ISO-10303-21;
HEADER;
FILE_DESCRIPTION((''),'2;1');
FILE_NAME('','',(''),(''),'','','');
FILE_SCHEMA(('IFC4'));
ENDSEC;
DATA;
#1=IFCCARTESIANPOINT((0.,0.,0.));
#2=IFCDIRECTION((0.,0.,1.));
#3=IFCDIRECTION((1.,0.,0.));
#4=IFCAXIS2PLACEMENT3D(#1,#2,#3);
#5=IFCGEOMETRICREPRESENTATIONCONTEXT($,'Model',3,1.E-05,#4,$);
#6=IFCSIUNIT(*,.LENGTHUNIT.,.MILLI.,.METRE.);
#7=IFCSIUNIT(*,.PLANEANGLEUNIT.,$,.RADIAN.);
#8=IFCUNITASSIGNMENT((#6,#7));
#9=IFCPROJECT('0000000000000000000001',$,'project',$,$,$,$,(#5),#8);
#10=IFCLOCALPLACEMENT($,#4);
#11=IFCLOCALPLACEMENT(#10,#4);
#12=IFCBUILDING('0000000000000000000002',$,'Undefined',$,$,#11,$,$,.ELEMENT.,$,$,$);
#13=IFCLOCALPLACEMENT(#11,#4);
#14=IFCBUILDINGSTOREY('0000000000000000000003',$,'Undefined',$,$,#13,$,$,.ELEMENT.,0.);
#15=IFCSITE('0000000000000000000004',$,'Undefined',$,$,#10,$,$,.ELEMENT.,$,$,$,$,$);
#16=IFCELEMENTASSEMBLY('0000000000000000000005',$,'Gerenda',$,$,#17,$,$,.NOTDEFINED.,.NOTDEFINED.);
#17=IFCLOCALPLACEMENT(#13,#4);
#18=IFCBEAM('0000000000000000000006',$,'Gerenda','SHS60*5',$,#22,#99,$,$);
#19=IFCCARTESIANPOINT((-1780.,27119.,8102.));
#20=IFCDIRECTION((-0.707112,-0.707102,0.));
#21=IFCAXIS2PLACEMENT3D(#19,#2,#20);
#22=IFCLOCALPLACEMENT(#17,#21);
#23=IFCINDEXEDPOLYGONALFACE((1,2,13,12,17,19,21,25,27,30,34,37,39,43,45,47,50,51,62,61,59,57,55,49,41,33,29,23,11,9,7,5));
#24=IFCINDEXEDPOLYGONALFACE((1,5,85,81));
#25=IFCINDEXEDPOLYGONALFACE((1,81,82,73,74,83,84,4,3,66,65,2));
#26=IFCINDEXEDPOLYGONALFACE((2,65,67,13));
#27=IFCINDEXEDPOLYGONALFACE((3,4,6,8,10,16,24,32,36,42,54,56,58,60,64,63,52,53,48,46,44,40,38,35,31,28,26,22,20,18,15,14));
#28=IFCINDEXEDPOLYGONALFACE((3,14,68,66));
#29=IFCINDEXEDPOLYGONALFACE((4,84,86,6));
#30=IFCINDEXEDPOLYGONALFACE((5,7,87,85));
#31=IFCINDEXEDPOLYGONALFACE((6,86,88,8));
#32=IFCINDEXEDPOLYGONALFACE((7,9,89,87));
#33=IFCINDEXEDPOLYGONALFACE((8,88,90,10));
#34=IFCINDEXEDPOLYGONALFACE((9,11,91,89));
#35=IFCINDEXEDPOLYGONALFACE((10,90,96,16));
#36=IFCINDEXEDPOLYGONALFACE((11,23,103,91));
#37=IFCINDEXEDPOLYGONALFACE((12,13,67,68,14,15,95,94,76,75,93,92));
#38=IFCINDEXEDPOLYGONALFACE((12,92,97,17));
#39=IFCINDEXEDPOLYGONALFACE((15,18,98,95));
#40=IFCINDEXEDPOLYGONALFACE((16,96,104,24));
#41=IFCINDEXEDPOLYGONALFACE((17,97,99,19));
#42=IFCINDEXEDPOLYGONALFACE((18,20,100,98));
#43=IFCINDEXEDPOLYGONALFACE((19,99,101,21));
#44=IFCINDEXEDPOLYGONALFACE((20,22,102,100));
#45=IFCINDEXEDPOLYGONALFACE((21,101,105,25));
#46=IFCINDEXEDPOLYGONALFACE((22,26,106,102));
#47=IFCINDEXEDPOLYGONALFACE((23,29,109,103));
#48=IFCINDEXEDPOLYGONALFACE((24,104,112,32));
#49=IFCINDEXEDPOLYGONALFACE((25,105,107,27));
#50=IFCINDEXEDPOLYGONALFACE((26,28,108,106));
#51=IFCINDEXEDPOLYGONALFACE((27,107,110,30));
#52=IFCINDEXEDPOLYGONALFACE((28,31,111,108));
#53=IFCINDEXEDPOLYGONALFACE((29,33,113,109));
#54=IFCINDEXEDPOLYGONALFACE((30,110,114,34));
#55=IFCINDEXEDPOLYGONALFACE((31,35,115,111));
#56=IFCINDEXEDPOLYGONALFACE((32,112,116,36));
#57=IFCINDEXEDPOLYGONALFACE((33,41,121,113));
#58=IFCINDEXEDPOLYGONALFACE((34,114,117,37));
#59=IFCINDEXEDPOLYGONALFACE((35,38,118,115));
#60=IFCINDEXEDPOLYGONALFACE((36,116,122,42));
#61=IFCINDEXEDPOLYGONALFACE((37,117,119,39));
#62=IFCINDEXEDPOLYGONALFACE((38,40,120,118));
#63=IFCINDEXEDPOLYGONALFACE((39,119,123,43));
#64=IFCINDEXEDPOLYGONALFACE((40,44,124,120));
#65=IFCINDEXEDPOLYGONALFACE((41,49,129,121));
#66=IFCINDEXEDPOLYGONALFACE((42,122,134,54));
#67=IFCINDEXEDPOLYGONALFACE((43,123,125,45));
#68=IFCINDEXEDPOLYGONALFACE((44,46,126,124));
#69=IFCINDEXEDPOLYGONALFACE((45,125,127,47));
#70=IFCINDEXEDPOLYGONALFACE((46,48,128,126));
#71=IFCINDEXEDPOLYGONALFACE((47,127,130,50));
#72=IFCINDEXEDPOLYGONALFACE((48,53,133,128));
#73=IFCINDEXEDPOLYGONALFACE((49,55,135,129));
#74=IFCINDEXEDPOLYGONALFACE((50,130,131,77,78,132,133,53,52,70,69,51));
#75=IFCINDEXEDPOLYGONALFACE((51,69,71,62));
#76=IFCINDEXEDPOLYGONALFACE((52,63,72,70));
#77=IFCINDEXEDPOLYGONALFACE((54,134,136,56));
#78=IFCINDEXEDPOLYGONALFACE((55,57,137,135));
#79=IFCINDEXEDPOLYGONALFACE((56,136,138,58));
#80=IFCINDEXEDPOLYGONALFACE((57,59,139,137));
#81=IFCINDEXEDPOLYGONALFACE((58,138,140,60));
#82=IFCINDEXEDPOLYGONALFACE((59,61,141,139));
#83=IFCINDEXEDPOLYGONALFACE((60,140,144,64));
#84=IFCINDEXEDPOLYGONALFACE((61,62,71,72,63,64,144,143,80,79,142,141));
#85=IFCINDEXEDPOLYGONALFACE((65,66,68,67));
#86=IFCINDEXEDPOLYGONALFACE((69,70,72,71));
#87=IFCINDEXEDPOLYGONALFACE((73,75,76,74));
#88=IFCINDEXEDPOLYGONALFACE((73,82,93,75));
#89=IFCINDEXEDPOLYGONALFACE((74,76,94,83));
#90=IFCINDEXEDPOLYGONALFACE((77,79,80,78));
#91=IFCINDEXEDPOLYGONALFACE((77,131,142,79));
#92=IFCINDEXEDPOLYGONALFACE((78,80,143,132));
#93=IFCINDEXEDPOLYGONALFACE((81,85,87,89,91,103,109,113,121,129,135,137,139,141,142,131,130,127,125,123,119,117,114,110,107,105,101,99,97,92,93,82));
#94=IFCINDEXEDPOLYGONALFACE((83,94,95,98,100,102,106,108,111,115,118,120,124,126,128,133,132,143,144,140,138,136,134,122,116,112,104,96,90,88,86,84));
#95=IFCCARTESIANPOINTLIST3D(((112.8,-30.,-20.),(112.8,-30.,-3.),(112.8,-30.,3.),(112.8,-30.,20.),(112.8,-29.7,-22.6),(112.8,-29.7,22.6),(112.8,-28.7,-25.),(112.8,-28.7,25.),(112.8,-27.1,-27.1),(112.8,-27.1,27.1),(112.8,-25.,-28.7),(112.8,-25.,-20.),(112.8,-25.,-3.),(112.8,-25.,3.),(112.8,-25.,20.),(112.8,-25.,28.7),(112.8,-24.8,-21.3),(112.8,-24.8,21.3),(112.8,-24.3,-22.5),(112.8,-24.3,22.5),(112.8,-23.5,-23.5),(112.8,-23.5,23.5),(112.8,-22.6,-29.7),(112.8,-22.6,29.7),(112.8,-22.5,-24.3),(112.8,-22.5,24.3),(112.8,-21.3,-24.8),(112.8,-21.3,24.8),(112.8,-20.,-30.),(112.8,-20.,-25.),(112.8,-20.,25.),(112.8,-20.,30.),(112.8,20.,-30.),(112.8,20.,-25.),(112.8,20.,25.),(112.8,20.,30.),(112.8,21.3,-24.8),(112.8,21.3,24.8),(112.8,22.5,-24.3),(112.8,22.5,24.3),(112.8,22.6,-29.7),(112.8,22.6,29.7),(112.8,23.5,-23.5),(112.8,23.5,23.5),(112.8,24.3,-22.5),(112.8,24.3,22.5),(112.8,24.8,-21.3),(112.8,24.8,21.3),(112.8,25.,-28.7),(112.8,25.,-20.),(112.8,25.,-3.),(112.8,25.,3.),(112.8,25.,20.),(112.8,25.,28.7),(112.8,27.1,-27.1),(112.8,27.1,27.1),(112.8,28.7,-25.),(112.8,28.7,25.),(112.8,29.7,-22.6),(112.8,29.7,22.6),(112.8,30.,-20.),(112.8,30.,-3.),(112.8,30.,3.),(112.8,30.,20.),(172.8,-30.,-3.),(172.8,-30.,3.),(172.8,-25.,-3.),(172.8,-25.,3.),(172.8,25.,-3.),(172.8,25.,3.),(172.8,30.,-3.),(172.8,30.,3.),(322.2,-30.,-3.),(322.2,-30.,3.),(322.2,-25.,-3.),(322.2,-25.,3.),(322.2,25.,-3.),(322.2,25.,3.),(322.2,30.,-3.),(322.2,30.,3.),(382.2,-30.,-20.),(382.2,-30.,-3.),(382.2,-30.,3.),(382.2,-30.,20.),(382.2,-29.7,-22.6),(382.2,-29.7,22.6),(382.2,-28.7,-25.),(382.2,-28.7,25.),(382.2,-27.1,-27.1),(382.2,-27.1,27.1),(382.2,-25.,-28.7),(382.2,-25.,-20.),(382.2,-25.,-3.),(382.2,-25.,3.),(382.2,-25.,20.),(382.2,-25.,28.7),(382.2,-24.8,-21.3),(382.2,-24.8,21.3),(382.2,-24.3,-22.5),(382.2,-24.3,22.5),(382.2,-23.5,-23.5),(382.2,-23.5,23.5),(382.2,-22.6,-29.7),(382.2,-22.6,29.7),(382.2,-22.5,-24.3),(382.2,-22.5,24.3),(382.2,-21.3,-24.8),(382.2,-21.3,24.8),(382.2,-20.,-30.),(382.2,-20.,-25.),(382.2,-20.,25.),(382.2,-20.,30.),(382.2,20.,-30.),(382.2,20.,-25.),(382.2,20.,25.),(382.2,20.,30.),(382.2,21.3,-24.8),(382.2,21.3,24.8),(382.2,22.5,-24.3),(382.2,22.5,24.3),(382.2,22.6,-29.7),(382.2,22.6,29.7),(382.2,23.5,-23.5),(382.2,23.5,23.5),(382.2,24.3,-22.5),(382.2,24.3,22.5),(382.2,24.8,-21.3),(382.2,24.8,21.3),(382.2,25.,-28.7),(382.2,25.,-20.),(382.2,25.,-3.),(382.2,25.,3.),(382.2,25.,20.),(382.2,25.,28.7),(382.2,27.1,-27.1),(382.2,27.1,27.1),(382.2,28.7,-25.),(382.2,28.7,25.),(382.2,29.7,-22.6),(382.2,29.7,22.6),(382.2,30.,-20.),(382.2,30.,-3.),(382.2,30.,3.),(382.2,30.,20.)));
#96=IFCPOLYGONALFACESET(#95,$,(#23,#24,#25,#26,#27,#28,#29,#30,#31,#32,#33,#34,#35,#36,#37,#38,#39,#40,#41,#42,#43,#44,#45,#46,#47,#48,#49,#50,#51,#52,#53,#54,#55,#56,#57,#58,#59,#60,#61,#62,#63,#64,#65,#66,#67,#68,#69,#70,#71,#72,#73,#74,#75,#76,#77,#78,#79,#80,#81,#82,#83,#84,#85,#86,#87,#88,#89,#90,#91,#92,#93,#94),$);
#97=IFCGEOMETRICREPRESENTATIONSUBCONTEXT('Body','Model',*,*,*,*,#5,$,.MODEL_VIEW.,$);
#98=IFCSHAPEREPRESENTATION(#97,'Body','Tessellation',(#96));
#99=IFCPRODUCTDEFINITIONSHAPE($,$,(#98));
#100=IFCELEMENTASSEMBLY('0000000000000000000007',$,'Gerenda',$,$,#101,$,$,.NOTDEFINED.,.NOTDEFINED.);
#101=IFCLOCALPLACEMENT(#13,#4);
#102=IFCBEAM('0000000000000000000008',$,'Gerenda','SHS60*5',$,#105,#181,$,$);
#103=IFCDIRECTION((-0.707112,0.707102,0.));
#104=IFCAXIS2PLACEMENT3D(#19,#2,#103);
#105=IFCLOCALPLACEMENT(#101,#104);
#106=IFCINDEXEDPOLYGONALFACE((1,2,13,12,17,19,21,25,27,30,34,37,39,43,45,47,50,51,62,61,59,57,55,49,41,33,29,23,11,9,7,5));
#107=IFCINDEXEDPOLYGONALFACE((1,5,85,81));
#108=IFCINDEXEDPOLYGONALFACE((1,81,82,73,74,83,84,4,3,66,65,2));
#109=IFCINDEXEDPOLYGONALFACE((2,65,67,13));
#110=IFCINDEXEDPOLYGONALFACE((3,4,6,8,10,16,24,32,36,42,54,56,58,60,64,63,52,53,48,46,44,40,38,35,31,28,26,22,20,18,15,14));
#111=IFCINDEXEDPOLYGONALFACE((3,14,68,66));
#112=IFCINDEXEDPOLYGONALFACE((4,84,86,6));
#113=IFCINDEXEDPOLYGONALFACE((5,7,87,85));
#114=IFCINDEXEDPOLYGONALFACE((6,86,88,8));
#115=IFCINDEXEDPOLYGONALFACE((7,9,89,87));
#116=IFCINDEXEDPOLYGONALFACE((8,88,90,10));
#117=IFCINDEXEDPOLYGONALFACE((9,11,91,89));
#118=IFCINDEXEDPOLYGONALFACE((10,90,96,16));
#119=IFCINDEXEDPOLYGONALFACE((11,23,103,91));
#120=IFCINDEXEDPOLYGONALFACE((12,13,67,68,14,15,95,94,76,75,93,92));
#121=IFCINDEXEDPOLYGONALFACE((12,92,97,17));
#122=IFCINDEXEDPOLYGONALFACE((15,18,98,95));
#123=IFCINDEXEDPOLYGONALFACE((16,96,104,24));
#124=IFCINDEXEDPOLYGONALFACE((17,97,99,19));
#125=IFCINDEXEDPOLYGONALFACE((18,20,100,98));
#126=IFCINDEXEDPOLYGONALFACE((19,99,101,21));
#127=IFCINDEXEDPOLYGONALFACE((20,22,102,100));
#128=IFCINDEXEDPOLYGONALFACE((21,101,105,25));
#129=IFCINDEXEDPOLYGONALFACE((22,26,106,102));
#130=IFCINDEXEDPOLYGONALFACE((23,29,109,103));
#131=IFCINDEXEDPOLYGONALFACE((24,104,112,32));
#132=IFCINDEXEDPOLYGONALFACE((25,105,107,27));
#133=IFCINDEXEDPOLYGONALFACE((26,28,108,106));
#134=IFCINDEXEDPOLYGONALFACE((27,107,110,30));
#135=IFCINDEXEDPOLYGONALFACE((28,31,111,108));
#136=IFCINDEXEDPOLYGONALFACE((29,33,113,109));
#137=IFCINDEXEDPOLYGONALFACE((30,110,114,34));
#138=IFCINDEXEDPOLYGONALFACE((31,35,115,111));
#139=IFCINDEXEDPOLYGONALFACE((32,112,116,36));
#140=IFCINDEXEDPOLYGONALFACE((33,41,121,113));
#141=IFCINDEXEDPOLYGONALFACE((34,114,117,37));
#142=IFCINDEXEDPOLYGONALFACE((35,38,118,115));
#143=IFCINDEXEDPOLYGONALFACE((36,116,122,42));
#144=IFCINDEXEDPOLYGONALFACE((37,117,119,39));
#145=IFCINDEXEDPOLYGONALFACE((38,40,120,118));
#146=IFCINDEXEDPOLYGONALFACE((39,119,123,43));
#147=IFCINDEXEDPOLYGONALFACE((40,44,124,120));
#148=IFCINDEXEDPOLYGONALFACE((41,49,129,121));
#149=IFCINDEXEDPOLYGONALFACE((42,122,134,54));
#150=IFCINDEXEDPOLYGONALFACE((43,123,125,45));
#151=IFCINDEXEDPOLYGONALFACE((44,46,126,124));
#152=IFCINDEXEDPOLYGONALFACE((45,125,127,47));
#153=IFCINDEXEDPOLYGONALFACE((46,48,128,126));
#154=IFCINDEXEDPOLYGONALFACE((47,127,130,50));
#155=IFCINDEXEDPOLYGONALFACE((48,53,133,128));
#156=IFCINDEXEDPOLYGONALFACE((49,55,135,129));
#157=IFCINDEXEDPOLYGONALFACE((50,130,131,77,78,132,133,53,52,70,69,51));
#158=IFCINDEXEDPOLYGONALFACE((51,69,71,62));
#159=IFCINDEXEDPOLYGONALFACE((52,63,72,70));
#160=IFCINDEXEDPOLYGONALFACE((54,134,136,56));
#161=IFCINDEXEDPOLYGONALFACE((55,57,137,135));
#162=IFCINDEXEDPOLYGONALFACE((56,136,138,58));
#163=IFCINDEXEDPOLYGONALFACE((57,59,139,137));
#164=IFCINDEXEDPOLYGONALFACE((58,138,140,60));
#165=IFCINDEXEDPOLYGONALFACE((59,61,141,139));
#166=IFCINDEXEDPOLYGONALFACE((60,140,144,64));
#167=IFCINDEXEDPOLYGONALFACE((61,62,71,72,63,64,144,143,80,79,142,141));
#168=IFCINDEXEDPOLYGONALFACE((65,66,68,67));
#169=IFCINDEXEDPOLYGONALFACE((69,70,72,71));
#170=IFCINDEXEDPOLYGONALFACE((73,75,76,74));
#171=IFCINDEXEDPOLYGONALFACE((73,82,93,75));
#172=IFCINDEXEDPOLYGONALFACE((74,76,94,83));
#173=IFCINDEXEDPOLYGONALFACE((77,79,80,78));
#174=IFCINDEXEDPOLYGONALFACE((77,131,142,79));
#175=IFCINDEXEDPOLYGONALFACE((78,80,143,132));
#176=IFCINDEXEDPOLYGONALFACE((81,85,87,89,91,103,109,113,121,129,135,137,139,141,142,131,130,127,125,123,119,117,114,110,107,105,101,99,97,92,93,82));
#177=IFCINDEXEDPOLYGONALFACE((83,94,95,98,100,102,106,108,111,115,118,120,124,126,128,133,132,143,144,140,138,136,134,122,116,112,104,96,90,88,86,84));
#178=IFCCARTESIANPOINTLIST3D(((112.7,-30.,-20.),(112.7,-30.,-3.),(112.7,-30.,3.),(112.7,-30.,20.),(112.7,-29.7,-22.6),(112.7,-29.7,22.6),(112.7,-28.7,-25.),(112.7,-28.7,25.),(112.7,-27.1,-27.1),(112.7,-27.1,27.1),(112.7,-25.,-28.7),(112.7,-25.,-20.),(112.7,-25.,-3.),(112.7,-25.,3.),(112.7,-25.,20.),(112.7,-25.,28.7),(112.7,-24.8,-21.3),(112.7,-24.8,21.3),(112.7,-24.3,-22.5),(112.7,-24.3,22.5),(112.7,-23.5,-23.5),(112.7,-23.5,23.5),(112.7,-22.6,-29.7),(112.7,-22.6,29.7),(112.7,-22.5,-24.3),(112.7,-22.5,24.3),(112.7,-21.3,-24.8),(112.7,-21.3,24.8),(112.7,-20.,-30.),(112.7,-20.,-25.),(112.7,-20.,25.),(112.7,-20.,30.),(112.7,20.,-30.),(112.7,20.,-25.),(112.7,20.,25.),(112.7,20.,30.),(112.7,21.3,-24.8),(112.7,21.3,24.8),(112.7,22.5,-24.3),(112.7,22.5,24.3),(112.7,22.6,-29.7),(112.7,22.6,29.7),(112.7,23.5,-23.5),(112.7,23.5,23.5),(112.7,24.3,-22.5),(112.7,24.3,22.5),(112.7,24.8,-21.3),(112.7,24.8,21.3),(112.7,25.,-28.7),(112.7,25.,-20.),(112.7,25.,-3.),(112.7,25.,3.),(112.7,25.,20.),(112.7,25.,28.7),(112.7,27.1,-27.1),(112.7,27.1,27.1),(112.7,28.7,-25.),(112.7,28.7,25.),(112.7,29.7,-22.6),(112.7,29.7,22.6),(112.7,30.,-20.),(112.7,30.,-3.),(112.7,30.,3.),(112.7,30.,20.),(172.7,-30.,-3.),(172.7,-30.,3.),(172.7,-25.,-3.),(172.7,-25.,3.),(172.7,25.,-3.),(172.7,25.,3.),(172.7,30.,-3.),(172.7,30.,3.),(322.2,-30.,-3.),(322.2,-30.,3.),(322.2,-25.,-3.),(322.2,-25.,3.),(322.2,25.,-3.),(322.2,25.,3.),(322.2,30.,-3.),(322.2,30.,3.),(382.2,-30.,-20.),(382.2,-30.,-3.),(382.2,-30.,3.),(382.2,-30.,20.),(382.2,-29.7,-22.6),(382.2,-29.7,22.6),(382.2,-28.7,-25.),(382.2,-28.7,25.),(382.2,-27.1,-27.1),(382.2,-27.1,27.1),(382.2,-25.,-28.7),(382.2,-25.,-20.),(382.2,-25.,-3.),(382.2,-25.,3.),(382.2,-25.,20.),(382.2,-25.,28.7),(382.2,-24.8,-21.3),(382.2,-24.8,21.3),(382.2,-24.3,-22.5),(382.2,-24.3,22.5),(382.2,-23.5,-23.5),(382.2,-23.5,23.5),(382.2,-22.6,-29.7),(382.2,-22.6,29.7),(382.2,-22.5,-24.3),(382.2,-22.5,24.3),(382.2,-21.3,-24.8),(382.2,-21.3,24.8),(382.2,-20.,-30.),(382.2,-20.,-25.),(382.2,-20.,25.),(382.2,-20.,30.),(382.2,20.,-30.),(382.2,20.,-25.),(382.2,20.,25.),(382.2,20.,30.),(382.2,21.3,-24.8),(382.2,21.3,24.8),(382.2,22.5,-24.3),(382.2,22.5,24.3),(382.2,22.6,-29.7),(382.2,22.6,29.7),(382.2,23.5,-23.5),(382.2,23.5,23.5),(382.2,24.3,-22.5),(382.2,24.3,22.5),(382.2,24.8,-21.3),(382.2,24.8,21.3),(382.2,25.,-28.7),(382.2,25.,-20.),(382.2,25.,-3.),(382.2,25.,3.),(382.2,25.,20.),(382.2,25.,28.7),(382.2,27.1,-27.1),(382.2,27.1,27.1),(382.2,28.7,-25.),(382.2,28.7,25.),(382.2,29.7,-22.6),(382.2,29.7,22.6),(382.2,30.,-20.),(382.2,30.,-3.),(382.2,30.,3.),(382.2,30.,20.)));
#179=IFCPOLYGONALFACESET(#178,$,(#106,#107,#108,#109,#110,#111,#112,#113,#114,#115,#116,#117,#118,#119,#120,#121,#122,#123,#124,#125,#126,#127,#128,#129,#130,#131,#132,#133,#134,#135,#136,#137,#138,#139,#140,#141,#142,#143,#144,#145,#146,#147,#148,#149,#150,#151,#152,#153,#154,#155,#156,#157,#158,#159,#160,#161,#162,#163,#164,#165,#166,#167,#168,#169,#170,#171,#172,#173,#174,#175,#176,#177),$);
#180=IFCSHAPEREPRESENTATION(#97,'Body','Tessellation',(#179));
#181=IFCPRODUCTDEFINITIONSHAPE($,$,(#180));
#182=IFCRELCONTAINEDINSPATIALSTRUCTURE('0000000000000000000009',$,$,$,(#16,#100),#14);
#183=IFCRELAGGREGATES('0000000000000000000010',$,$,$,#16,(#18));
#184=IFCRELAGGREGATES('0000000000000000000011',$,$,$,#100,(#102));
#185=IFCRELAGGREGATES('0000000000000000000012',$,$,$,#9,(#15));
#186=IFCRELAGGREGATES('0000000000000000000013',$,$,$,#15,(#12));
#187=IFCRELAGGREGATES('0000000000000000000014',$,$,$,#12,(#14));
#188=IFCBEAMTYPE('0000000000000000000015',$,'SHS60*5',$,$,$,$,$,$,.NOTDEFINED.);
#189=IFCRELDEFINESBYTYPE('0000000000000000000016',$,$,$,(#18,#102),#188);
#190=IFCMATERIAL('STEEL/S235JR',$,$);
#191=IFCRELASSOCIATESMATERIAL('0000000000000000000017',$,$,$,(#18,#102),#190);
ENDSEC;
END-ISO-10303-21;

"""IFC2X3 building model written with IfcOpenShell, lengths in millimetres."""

from ifc_helpers import new_model, si_unit, frame, origin_with_axes, origin_2d_with_axis, place, context, subcontext, project, spatial, rectangle, hollow_rectangle, extrude, boolean, halfspace, material, type_object, element, aggregate, save


model = new_model("IFC2X3")

# Units and contexts
model_context = context("Model", 3, precision=1e-05, world=origin_with_axes())
body_context = subcontext(model_context, "Body", "Model", "MODEL_VIEW")
ifc_project = project(units=[si_unit("LENGTHUNIT", "METRE", prefix="MILLI"), si_unit("PLANEANGLEUNIT", "RADIAN")], contexts=[model_context])

# Site, building, storey
site_placement = place(None, origin_with_axes())
site = spatial("IfcSite", under=ifc_project, at=site_placement, Name="Undefined", CompositionType="ELEMENT")
building_placement = place(site_placement, origin_with_axes())
building = spatial("IfcBuilding", under=site, at=building_placement, Name="Undefined", CompositionType="ELEMENT")
storey_placement = place(building_placement, origin_with_axes())
storey = spatial("IfcBuildingStorey", under=building, at=storey_placement, Name="Undefined", CompositionType="ELEMENT", Elevation=0.0)

# Element assemblies, beams
assembly_1_placement = place(storey_placement, origin_with_axes())
assembly_1 = element("IfcElementAssembly", 1, at=assembly_1_placement, inside=storey, Name="Gerenda", AssemblyPlace="NOTDEFINED", PredefinedType="NOTDEFINED")
ifc_material_1 = material(Name="STEEL/S235JR")
beam_type_1 = type_object("IfcBeamType", Name="SHS60*5", PredefinedType="NOTDEFINED")
beam_1_placement = place(assembly_1_placement, frame((-1780.0, 27119.0, 8102.0), z_axis=(0.0, 0.0, 1.0), x_axis=(-0.707112, -0.707102, 0.0)))
beam_1 = element("IfcBeam", 2, at=beam_1_placement, type_object=beam_type_1, material=ifc_material_1, Name="Gerenda", Description="SHS60*5", context=body_context, shape_type="CSG", body=[
    boolean("DIFFERENCE", boolean("DIFFERENCE", boolean("DIFFERENCE", boolean("DIFFERENCE", extrude(hollow_rectangle(XDim=60.0, YDim=60.0, WallThickness=5.0, InnerFilletRadius=5.0, OuterFilletRadius=10.0, at=origin_2d_with_axis()), frame((442.8, 0.0, 0.0), z_axis=(-1.0, 0.0, 0.0), x_axis=(0.0, -1.0, 0.0)), (0.0, 0.0, 1.0), 442.8), extrude(rectangle(XDim=6.0, YDim=64.0, at=origin_2d_with_axis()), frame((322.2, 0.0, 0.0), z_axis=(1.0, 0.0, 0.0), x_axis=(0.0, 0.0, -1.0)), (0.0, 0.0, 1.0), 62.0)), extrude(rectangle(XDim=6.0, YDim=64.0, at=origin_2d_with_axis()), frame((172.8, 0.0, 0.0), z_axis=(-1.0, 0.0, 0.0), x_axis=(0.0, 0.0, -1.0)), (0.0, 0.0, 1.0), 62.0)), halfspace(frame((382.2, 0.0, -9.0), z_axis=(-1.0, 0.0, 0.0), x_axis=(0.0, 1.0, 0.0)), True)), halfspace(frame((112.8, 0.0, -9.0), z_axis=(1.0, 0.0, 0.0), x_axis=(0.0, -1.0, 0.0)), True)),
])
aggregate(assembly_1, [beam_1])
assembly_2_placement = place(storey_placement, origin_with_axes())
assembly_2 = element("IfcElementAssembly", 3, at=assembly_2_placement, inside=storey, Name="Gerenda", AssemblyPlace="NOTDEFINED", PredefinedType="NOTDEFINED")
beam_2_placement = place(assembly_2_placement, frame((-1780.0, 27119.0, 8102.0), z_axis=(0.0, 0.0, 1.0), x_axis=(-0.707112, 0.707102, 0.0)))
beam_2 = element("IfcBeam", 4, at=beam_2_placement, type_object=beam_type_1, material=ifc_material_1, Name="Gerenda", Description="SHS60*5", context=body_context, shape_type="CSG", body=[
    boolean("DIFFERENCE", boolean("DIFFERENCE", boolean("DIFFERENCE", boolean("DIFFERENCE", extrude(hollow_rectangle(XDim=60.0, YDim=60.0, WallThickness=5.0, InnerFilletRadius=5.0, OuterFilletRadius=10.0, at=origin_2d_with_axis()), frame((442.8, 0.0, 0.0), z_axis=(-1.0, 0.0, 0.0), x_axis=(0.0, -1.0, 0.0)), (0.0, 0.0, 1.0), 442.8), extrude(rectangle(XDim=6.0, YDim=64.0, at=origin_2d_with_axis()), frame((322.2, 0.0, 0.0), z_axis=(1.0, 0.0, 0.0), x_axis=(0.0, 0.0, -1.0)), (0.0, 0.0, 1.0), 62.0)), extrude(rectangle(XDim=6.0, YDim=64.0, at=origin_2d_with_axis()), frame((172.7, 0.0, 0.0), z_axis=(-1.0, 0.0, 0.0), x_axis=(0.0, 0.0, -1.0)), (0.0, 0.0, 1.0), 62.0)), halfspace(frame((382.2, 0.0, -9.0), z_axis=(-1.0, 0.0, 0.0), x_axis=(0.0, 1.0, 0.0)), True)), halfspace(frame((112.7, 0.0, -9.0), z_axis=(1.0, 0.0, 0.0), x_axis=(0.0, -1.0, 0.0)), True)),
])

aggregate(assembly_2, [beam_2])

save(model, "model.ifc")
